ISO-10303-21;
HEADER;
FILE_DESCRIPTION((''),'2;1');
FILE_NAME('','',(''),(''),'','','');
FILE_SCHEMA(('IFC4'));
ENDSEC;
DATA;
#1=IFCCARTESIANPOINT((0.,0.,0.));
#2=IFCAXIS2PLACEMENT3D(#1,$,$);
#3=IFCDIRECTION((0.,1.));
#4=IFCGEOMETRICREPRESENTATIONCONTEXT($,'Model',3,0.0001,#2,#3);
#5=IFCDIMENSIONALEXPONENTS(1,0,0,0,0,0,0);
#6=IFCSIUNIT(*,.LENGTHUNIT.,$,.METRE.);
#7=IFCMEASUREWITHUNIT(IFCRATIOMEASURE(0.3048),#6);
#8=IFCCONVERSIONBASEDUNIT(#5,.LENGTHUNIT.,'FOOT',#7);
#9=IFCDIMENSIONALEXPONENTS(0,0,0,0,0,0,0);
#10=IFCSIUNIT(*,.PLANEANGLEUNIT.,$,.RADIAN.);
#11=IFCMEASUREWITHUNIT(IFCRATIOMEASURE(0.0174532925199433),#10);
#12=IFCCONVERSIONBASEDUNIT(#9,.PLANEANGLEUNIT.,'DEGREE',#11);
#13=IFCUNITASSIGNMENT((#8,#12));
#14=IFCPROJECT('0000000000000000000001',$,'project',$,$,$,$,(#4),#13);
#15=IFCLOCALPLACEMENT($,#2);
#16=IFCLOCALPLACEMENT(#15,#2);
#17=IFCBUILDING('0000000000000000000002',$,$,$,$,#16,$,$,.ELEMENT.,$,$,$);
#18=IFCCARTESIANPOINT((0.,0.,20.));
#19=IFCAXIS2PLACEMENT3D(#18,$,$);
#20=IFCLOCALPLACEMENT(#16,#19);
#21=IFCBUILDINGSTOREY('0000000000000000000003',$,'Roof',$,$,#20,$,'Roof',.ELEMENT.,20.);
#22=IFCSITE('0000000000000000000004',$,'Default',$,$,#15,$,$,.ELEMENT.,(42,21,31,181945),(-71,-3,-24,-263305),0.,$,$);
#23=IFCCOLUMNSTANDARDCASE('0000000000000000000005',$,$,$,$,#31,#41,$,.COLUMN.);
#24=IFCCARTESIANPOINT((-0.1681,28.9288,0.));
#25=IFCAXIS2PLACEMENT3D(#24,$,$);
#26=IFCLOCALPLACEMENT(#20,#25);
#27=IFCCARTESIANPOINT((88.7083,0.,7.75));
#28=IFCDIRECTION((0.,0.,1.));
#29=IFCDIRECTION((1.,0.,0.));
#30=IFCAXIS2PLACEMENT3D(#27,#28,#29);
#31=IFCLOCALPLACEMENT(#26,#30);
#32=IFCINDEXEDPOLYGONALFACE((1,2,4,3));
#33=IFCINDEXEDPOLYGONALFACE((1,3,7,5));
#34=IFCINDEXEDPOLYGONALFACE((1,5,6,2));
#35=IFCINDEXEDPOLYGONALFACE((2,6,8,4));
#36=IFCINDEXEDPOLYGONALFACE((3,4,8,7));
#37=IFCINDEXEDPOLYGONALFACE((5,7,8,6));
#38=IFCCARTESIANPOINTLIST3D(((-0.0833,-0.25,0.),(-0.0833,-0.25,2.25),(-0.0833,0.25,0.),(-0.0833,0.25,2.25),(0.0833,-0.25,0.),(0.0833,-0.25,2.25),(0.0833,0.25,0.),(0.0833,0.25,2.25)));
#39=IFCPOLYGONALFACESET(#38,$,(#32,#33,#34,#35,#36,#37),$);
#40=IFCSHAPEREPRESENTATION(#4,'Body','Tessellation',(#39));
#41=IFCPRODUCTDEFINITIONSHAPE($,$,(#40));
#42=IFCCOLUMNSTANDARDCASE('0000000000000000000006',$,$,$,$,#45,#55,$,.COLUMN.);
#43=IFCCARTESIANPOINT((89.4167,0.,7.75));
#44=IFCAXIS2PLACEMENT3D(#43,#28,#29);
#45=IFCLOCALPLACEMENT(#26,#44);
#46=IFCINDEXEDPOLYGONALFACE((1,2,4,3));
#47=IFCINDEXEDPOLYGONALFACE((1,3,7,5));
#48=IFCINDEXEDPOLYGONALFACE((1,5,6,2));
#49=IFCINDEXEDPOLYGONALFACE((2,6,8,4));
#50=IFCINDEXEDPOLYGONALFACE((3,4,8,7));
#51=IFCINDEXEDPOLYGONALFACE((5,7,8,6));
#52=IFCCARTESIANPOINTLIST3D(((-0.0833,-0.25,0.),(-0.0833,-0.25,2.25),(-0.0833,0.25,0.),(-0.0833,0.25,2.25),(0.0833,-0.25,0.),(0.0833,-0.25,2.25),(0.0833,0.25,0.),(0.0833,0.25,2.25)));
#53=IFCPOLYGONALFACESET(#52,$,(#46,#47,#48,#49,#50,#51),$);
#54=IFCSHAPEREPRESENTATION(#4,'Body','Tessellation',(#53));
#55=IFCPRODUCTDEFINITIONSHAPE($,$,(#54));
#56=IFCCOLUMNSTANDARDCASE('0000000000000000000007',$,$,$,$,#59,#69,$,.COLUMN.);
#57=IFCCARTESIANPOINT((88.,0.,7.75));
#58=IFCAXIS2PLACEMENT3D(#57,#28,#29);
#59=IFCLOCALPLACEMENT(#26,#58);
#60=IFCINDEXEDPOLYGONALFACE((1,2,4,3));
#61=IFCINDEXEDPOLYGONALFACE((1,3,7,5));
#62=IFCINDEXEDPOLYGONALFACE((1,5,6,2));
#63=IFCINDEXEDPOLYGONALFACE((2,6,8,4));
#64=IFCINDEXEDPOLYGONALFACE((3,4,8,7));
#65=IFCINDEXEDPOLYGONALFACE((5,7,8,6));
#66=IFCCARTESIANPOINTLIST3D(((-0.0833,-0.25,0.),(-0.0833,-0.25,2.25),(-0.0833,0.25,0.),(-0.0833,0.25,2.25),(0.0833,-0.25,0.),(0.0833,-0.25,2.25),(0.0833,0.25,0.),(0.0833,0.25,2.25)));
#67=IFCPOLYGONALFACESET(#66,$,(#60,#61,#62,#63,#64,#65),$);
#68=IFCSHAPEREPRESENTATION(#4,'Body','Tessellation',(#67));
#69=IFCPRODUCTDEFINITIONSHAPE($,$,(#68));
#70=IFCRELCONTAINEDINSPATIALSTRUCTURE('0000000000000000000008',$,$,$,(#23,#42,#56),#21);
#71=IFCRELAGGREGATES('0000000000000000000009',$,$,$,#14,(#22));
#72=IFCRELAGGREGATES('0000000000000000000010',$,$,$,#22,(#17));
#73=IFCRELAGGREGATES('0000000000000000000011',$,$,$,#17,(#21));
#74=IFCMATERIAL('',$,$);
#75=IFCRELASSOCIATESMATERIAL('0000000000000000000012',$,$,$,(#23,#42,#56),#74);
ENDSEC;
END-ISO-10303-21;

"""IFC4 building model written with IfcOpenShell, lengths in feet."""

from ifc_helpers import new_model, entity, si_unit, converted_unit, direction, frame, origin, place, context, project, spatial, rectangle, extrude, material, element, save


model = new_model("IFC4")

# Units and contexts
model_context = context("Model", 3, precision=0.0001, world=origin(), true_north=direction((0.0, 1.0)))
ifc_project = project(units=[converted_unit("LENGTHUNIT", "FOOT", entity("IfcRatioMeasure", 0.3048), si_unit("LENGTHUNIT", "METRE"), dimensions=[1, 0, 0, 0, 0, 0, 0]), converted_unit("PLANEANGLEUNIT", "DEGREE", entity("IfcRatioMeasure", 0.0174532925199433), si_unit("PLANEANGLEUNIT", "RADIAN"), dimensions=[0, 0, 0, 0, 0, 0, 0])], contexts=[model_context])

# Site, building, storey
site_placement = place(None, origin())
site = spatial("IfcSite", under=ifc_project, at=site_placement, Name="Default", CompositionType="ELEMENT", RefLatitude=(42, 21, 31, 181945), RefLongitude=(-71, -3, -24, -263305), RefElevation=0.0)
building_placement = place(site_placement, origin())
building = spatial("IfcBuilding", under=site, at=building_placement, CompositionType="ELEMENT")
storey_placement = place(building_placement, frame((0.0, 0.0, 20.0)))
storey = spatial("IfcBuildingStorey", under=building, at=storey_placement, Name="Roof", LongName="Roof", CompositionType="ELEMENT", Elevation=20.0)

# Columns
ifc_material = material(Name="")
placement = place(storey_placement, frame((-0.1681, 28.9288, 0.0)))
for number, where, z_axis, x_axis in (
    (1, (88.7083, 0.0, 7.75), (0.0, 0.0, 1.0), (1.0, 0.0, 0.0)),
    (2, (89.4167, 0.0, 7.75), (0.0, 0.0, 1.0), (1.0, 0.0, 0.0)),
    (3, (88.0, 0.0, 7.75), (0.0, 0.0, 1.0), (1.0, 0.0, 0.0)),
):
    element("IfcColumnStandardCase", number, at=place(placement, frame(where, z_axis=z_axis, x_axis=x_axis)), inside=storey, material=ifc_material, PredefinedType="COLUMN", context=model_context, shape_type="SweptSolid", body=[
        extrude(rectangle(XDim=0.1667, YDim=0.5), origin(), (0.0, 0.0, 1.0), 2.25),
    ])

save(model, "model.ifc")
